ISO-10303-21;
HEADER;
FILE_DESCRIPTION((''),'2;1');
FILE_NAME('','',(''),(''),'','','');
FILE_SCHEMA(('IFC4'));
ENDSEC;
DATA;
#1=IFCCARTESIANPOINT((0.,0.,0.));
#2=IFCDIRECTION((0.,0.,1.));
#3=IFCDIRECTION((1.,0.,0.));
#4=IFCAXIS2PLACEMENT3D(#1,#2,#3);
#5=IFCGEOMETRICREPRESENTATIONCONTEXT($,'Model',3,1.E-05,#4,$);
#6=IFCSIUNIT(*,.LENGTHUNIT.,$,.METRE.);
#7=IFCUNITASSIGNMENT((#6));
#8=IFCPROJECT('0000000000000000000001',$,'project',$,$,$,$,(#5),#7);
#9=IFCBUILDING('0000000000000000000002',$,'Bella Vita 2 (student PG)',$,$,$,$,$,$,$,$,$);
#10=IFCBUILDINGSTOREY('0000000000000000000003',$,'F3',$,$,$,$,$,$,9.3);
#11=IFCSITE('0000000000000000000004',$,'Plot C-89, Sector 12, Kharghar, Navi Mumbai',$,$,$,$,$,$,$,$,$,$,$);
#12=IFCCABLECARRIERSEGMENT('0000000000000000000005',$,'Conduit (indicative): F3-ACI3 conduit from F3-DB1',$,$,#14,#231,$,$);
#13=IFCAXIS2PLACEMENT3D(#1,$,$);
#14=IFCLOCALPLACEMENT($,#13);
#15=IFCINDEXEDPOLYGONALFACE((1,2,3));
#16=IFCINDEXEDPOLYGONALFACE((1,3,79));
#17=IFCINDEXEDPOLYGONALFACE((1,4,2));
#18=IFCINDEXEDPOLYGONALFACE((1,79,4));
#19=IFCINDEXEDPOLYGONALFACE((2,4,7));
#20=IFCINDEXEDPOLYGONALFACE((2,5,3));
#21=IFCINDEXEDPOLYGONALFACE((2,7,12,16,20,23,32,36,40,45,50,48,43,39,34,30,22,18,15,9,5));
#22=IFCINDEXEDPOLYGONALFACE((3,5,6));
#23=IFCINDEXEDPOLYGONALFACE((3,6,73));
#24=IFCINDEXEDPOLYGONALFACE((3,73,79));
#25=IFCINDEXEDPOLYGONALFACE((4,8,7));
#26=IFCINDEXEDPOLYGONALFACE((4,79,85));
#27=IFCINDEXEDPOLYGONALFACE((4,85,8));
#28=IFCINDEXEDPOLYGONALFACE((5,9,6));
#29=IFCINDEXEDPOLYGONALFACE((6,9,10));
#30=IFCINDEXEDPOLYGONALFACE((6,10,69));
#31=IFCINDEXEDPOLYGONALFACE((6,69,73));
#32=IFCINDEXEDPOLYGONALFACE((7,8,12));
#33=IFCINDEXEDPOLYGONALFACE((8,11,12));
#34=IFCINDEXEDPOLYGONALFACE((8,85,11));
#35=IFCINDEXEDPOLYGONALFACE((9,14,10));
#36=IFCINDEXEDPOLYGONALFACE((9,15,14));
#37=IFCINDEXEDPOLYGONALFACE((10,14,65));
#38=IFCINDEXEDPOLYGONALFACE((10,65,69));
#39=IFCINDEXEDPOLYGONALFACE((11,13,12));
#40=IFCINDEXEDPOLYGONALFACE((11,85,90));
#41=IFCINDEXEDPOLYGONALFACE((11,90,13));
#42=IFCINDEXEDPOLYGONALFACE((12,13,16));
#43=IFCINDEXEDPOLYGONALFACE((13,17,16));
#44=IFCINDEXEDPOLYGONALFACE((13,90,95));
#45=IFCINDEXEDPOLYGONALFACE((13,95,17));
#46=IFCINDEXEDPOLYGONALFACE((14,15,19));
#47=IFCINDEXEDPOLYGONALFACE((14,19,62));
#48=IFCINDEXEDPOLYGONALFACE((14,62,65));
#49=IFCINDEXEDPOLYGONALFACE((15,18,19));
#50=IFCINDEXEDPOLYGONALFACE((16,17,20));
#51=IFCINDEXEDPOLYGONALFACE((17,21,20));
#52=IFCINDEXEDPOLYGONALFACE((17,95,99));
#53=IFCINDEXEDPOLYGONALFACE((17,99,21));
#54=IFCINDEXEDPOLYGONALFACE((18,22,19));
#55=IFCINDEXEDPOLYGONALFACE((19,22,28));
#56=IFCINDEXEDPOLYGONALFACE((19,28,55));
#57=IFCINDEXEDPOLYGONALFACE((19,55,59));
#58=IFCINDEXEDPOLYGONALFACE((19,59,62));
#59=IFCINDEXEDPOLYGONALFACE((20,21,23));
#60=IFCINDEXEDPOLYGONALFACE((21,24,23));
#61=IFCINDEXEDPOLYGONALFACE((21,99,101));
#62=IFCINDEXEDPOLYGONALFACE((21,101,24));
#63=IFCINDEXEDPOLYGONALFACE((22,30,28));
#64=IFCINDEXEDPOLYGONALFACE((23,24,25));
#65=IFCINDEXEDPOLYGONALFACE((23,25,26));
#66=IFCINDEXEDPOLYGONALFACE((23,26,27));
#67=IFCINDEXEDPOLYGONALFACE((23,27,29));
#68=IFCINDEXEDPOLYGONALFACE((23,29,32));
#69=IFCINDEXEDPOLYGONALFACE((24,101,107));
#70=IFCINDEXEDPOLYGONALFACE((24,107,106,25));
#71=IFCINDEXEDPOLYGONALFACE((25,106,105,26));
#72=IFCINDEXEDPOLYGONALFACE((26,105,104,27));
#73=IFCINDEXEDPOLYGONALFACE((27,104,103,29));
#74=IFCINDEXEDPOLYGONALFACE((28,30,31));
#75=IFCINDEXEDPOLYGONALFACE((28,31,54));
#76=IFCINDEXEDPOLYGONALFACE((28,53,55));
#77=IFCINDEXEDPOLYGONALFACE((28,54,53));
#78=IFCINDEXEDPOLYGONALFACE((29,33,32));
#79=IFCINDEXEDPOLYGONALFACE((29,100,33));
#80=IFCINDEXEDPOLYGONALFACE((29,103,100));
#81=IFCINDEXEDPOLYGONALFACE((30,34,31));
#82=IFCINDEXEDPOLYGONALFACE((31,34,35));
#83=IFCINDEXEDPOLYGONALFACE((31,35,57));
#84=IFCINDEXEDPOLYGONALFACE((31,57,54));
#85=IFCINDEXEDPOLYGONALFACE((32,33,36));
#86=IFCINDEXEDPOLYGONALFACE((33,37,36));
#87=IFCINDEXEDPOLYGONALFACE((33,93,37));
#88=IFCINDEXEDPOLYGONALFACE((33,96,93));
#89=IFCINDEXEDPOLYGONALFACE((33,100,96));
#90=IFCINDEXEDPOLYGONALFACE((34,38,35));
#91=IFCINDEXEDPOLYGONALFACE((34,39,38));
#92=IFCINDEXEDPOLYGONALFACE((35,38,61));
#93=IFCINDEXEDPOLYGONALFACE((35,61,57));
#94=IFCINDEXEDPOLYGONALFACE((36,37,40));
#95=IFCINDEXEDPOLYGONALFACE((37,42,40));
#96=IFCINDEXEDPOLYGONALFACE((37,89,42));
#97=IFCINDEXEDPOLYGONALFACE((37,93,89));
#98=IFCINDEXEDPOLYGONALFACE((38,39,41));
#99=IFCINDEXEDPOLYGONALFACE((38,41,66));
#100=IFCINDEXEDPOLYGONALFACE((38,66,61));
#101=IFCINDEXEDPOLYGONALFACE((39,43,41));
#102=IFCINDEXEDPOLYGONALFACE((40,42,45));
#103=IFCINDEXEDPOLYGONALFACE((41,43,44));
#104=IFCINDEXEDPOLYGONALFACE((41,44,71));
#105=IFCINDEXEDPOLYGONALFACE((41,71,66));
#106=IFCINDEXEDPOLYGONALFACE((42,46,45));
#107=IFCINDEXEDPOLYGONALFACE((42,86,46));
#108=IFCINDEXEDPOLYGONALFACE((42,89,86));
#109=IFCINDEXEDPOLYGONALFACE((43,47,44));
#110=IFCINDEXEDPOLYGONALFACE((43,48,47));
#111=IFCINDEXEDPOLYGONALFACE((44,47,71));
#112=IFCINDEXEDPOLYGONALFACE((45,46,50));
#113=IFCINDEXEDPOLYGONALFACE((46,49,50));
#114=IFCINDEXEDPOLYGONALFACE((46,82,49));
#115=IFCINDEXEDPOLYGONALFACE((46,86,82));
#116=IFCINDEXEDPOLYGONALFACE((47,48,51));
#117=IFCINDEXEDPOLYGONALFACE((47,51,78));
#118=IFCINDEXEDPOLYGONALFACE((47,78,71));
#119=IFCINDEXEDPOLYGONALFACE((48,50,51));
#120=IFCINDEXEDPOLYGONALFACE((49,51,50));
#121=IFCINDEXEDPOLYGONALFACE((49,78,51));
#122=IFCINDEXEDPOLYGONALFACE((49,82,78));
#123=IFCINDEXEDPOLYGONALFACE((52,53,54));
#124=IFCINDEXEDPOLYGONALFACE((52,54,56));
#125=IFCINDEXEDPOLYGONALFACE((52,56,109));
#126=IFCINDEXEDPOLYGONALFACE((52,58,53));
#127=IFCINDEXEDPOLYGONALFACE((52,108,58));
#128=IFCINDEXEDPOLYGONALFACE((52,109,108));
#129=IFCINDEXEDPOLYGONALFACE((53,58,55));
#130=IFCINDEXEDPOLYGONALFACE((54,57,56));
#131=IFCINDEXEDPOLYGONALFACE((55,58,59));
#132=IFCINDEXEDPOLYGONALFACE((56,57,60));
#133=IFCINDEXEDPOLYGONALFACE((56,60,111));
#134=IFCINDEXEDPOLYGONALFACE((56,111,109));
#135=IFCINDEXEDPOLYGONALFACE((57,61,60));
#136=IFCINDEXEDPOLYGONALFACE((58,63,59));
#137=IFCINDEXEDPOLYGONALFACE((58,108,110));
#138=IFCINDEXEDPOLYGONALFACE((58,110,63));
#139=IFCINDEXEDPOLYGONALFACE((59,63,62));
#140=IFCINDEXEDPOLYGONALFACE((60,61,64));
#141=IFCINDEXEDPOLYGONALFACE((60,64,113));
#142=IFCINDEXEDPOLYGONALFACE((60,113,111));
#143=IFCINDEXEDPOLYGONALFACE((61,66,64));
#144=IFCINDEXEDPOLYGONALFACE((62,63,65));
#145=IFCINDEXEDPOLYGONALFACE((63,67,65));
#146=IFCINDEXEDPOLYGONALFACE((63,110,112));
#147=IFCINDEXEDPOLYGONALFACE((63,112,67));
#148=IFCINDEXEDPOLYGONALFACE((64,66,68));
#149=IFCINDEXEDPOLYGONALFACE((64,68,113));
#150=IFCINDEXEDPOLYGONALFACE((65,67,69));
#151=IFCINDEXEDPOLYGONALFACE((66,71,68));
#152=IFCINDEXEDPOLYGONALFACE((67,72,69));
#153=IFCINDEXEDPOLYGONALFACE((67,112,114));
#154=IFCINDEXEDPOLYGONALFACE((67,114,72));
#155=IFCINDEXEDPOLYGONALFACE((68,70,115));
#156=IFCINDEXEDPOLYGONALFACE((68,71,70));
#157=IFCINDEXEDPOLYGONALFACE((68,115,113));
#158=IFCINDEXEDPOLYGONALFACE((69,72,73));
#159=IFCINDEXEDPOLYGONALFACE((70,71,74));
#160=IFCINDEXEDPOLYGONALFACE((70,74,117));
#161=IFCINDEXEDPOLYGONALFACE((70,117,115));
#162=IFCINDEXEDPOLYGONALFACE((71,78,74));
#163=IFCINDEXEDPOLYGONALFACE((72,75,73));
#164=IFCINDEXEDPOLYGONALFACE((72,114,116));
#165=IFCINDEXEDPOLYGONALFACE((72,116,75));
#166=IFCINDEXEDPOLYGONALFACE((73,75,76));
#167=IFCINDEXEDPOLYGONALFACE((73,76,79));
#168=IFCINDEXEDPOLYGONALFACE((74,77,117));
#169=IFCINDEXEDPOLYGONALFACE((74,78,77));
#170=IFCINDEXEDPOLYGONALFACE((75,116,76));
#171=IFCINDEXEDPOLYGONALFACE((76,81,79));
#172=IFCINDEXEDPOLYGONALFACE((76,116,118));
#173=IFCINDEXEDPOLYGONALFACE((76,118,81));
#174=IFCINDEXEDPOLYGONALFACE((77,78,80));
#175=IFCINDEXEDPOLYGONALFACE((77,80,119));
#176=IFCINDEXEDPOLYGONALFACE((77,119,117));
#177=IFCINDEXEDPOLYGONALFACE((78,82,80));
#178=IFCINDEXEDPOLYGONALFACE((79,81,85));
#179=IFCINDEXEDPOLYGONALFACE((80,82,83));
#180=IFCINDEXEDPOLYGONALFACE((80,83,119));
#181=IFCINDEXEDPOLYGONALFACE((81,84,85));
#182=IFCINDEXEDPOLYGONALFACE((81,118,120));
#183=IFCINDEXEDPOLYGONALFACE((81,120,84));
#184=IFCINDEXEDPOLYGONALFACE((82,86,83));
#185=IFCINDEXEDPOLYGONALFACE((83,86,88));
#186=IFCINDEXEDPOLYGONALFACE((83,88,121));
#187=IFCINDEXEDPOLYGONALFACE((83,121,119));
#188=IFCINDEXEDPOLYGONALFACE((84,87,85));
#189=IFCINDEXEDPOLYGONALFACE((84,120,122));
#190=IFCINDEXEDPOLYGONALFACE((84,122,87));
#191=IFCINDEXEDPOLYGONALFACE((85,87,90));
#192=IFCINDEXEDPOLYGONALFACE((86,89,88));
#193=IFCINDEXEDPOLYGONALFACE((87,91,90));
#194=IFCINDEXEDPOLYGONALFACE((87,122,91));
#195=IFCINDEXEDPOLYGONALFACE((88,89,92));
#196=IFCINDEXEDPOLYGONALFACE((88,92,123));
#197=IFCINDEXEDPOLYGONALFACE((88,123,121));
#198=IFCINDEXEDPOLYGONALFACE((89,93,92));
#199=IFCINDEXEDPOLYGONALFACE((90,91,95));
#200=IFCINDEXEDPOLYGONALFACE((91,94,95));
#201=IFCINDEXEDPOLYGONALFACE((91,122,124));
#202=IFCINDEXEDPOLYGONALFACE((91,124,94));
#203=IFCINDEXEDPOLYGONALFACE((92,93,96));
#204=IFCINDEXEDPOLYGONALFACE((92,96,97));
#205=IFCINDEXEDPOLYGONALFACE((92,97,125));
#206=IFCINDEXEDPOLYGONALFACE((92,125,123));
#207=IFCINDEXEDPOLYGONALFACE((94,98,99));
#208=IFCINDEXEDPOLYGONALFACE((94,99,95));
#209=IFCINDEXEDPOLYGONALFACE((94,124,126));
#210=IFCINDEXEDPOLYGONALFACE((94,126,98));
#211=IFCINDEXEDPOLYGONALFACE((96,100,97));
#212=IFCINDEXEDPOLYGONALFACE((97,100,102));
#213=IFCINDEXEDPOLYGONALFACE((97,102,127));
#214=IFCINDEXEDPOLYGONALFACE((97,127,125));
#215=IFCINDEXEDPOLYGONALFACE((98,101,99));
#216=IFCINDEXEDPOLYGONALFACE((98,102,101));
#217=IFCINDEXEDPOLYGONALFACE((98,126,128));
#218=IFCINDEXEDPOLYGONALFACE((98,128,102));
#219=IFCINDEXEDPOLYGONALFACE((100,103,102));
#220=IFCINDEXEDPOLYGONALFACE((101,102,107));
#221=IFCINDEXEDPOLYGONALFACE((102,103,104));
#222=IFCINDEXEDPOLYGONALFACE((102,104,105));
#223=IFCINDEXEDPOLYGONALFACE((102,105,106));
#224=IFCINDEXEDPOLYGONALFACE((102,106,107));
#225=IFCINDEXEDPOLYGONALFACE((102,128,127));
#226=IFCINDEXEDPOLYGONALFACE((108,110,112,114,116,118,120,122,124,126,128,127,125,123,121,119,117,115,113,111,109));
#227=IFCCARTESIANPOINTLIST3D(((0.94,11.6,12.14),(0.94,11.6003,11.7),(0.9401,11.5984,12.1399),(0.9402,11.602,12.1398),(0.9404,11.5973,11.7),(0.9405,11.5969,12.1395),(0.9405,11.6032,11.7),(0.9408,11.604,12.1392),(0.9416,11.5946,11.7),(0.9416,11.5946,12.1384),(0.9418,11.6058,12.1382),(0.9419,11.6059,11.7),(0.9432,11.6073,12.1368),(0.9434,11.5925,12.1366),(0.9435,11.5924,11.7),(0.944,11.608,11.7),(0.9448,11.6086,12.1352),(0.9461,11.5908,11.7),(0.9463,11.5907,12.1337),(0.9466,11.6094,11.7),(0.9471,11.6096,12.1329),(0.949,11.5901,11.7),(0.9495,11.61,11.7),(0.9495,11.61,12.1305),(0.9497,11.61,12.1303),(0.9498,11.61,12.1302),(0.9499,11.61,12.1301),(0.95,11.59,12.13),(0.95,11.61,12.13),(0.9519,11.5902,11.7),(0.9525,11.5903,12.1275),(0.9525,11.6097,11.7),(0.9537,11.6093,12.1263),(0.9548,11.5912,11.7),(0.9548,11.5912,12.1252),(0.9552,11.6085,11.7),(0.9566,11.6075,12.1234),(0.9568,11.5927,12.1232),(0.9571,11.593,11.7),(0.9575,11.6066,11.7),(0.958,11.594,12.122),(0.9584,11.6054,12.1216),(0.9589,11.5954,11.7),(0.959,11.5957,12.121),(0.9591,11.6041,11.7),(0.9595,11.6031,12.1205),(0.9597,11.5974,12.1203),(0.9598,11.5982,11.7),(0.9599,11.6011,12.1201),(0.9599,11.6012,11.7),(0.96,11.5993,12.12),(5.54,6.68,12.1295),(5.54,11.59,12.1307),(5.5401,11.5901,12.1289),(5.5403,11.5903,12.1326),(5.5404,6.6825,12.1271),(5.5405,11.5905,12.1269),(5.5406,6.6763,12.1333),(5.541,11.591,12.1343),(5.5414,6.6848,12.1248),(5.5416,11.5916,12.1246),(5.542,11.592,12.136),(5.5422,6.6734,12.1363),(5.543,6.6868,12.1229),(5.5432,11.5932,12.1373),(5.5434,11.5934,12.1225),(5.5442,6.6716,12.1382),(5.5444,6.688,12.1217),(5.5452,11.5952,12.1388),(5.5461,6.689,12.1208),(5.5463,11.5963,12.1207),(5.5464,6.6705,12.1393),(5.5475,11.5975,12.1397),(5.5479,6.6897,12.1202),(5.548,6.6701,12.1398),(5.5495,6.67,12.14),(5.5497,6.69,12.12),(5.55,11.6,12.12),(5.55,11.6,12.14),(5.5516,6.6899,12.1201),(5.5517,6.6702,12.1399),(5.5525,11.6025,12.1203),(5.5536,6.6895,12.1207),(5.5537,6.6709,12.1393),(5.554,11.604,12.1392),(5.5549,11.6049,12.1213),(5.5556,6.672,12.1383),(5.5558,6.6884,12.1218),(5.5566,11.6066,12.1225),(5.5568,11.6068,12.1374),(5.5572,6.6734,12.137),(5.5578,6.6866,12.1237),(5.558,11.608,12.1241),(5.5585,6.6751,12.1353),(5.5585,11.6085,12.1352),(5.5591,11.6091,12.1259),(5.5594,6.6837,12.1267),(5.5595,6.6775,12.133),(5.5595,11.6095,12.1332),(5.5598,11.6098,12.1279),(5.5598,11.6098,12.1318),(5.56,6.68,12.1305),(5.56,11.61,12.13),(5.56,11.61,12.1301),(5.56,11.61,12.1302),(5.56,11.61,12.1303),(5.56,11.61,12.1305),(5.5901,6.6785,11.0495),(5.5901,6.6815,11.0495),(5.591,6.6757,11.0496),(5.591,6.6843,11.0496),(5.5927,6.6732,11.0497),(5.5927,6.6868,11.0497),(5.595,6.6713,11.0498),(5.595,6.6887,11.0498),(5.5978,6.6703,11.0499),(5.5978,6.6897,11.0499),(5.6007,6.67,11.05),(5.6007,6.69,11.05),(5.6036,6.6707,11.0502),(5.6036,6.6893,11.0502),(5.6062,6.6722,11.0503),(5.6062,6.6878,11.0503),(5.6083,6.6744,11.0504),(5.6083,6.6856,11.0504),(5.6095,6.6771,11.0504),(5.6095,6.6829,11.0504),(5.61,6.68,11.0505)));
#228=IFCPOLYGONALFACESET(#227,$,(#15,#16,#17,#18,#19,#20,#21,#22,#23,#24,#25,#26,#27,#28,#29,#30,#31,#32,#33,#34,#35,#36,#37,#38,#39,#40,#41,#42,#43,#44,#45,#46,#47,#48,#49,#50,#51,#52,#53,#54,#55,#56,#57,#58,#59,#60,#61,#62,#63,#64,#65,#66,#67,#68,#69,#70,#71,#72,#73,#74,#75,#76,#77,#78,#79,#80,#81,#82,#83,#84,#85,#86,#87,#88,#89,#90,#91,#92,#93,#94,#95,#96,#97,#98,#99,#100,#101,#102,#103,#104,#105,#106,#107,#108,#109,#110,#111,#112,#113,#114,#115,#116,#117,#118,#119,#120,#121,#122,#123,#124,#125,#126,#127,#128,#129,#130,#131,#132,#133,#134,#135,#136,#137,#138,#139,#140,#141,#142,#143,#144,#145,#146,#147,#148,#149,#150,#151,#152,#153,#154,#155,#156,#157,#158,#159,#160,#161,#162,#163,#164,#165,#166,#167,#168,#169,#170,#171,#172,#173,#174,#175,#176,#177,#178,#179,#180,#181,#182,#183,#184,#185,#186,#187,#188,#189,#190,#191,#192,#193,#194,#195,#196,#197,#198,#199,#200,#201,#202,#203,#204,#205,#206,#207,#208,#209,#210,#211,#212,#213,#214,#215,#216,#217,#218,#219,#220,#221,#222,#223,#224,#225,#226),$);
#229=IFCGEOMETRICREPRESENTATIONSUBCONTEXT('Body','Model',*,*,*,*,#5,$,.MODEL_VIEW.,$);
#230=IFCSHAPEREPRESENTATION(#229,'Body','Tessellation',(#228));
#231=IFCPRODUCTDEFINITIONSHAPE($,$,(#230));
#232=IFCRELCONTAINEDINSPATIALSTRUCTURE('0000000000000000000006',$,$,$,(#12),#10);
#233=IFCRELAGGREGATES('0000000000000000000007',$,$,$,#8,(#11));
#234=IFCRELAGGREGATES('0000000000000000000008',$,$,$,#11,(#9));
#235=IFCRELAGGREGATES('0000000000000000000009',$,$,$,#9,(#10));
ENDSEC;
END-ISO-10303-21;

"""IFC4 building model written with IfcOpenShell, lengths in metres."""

from ifc_helpers import new_model, entity, si_unit, origin, origin_with_axes, place, context, subcontext, project, spatial, element, save


model = new_model("IFC4")

# Units and contexts
model_context = context("Model", 3, precision=1e-05, world=origin_with_axes())
body_context = subcontext(model_context, "Body", "Model", "MODEL_VIEW")
ifc_project = project(units=[si_unit("LENGTHUNIT", "METRE")], contexts=[model_context])

# Site, building, storey
site = spatial("IfcSite", under=ifc_project, Name="Plot C-89, Sector 12, Kharghar, Navi Mumbai")
building = spatial("IfcBuilding", under=site, Name="Bella Vita 2 (student PG)")
storey = spatial("IfcBuildingStorey", under=building, Name="F3", Elevation=9.3)

# Cable carrier segment
cable_carrier_segment_1_placement = place(None, origin())
element("IfcCableCarrierSegment", 1, at=cable_carrier_segment_1_placement, inside=storey, Name="Conduit (indicative): F3-ACI3 conduit from F3-DB1", context=body_context, shape_type="AdvancedSweptSolid", body=[
    entity("IfcSweptDiskSolid", entity("IfcPolyline", [entity("IfcCartesianPoint", [5.6, 6.68, 11.05]), entity("IfcCartesianPoint", [5.55, 6.68, 12.13]), entity("IfcCartesianPoint", [5.55, 11.6, 12.13]), entity("IfcCartesianPoint", [0.95, 11.6, 12.13]), entity("IfcCartesianPoint", [0.95, 11.6, 11.7])]), 0.01),
])

save(model, "model.ifc")
